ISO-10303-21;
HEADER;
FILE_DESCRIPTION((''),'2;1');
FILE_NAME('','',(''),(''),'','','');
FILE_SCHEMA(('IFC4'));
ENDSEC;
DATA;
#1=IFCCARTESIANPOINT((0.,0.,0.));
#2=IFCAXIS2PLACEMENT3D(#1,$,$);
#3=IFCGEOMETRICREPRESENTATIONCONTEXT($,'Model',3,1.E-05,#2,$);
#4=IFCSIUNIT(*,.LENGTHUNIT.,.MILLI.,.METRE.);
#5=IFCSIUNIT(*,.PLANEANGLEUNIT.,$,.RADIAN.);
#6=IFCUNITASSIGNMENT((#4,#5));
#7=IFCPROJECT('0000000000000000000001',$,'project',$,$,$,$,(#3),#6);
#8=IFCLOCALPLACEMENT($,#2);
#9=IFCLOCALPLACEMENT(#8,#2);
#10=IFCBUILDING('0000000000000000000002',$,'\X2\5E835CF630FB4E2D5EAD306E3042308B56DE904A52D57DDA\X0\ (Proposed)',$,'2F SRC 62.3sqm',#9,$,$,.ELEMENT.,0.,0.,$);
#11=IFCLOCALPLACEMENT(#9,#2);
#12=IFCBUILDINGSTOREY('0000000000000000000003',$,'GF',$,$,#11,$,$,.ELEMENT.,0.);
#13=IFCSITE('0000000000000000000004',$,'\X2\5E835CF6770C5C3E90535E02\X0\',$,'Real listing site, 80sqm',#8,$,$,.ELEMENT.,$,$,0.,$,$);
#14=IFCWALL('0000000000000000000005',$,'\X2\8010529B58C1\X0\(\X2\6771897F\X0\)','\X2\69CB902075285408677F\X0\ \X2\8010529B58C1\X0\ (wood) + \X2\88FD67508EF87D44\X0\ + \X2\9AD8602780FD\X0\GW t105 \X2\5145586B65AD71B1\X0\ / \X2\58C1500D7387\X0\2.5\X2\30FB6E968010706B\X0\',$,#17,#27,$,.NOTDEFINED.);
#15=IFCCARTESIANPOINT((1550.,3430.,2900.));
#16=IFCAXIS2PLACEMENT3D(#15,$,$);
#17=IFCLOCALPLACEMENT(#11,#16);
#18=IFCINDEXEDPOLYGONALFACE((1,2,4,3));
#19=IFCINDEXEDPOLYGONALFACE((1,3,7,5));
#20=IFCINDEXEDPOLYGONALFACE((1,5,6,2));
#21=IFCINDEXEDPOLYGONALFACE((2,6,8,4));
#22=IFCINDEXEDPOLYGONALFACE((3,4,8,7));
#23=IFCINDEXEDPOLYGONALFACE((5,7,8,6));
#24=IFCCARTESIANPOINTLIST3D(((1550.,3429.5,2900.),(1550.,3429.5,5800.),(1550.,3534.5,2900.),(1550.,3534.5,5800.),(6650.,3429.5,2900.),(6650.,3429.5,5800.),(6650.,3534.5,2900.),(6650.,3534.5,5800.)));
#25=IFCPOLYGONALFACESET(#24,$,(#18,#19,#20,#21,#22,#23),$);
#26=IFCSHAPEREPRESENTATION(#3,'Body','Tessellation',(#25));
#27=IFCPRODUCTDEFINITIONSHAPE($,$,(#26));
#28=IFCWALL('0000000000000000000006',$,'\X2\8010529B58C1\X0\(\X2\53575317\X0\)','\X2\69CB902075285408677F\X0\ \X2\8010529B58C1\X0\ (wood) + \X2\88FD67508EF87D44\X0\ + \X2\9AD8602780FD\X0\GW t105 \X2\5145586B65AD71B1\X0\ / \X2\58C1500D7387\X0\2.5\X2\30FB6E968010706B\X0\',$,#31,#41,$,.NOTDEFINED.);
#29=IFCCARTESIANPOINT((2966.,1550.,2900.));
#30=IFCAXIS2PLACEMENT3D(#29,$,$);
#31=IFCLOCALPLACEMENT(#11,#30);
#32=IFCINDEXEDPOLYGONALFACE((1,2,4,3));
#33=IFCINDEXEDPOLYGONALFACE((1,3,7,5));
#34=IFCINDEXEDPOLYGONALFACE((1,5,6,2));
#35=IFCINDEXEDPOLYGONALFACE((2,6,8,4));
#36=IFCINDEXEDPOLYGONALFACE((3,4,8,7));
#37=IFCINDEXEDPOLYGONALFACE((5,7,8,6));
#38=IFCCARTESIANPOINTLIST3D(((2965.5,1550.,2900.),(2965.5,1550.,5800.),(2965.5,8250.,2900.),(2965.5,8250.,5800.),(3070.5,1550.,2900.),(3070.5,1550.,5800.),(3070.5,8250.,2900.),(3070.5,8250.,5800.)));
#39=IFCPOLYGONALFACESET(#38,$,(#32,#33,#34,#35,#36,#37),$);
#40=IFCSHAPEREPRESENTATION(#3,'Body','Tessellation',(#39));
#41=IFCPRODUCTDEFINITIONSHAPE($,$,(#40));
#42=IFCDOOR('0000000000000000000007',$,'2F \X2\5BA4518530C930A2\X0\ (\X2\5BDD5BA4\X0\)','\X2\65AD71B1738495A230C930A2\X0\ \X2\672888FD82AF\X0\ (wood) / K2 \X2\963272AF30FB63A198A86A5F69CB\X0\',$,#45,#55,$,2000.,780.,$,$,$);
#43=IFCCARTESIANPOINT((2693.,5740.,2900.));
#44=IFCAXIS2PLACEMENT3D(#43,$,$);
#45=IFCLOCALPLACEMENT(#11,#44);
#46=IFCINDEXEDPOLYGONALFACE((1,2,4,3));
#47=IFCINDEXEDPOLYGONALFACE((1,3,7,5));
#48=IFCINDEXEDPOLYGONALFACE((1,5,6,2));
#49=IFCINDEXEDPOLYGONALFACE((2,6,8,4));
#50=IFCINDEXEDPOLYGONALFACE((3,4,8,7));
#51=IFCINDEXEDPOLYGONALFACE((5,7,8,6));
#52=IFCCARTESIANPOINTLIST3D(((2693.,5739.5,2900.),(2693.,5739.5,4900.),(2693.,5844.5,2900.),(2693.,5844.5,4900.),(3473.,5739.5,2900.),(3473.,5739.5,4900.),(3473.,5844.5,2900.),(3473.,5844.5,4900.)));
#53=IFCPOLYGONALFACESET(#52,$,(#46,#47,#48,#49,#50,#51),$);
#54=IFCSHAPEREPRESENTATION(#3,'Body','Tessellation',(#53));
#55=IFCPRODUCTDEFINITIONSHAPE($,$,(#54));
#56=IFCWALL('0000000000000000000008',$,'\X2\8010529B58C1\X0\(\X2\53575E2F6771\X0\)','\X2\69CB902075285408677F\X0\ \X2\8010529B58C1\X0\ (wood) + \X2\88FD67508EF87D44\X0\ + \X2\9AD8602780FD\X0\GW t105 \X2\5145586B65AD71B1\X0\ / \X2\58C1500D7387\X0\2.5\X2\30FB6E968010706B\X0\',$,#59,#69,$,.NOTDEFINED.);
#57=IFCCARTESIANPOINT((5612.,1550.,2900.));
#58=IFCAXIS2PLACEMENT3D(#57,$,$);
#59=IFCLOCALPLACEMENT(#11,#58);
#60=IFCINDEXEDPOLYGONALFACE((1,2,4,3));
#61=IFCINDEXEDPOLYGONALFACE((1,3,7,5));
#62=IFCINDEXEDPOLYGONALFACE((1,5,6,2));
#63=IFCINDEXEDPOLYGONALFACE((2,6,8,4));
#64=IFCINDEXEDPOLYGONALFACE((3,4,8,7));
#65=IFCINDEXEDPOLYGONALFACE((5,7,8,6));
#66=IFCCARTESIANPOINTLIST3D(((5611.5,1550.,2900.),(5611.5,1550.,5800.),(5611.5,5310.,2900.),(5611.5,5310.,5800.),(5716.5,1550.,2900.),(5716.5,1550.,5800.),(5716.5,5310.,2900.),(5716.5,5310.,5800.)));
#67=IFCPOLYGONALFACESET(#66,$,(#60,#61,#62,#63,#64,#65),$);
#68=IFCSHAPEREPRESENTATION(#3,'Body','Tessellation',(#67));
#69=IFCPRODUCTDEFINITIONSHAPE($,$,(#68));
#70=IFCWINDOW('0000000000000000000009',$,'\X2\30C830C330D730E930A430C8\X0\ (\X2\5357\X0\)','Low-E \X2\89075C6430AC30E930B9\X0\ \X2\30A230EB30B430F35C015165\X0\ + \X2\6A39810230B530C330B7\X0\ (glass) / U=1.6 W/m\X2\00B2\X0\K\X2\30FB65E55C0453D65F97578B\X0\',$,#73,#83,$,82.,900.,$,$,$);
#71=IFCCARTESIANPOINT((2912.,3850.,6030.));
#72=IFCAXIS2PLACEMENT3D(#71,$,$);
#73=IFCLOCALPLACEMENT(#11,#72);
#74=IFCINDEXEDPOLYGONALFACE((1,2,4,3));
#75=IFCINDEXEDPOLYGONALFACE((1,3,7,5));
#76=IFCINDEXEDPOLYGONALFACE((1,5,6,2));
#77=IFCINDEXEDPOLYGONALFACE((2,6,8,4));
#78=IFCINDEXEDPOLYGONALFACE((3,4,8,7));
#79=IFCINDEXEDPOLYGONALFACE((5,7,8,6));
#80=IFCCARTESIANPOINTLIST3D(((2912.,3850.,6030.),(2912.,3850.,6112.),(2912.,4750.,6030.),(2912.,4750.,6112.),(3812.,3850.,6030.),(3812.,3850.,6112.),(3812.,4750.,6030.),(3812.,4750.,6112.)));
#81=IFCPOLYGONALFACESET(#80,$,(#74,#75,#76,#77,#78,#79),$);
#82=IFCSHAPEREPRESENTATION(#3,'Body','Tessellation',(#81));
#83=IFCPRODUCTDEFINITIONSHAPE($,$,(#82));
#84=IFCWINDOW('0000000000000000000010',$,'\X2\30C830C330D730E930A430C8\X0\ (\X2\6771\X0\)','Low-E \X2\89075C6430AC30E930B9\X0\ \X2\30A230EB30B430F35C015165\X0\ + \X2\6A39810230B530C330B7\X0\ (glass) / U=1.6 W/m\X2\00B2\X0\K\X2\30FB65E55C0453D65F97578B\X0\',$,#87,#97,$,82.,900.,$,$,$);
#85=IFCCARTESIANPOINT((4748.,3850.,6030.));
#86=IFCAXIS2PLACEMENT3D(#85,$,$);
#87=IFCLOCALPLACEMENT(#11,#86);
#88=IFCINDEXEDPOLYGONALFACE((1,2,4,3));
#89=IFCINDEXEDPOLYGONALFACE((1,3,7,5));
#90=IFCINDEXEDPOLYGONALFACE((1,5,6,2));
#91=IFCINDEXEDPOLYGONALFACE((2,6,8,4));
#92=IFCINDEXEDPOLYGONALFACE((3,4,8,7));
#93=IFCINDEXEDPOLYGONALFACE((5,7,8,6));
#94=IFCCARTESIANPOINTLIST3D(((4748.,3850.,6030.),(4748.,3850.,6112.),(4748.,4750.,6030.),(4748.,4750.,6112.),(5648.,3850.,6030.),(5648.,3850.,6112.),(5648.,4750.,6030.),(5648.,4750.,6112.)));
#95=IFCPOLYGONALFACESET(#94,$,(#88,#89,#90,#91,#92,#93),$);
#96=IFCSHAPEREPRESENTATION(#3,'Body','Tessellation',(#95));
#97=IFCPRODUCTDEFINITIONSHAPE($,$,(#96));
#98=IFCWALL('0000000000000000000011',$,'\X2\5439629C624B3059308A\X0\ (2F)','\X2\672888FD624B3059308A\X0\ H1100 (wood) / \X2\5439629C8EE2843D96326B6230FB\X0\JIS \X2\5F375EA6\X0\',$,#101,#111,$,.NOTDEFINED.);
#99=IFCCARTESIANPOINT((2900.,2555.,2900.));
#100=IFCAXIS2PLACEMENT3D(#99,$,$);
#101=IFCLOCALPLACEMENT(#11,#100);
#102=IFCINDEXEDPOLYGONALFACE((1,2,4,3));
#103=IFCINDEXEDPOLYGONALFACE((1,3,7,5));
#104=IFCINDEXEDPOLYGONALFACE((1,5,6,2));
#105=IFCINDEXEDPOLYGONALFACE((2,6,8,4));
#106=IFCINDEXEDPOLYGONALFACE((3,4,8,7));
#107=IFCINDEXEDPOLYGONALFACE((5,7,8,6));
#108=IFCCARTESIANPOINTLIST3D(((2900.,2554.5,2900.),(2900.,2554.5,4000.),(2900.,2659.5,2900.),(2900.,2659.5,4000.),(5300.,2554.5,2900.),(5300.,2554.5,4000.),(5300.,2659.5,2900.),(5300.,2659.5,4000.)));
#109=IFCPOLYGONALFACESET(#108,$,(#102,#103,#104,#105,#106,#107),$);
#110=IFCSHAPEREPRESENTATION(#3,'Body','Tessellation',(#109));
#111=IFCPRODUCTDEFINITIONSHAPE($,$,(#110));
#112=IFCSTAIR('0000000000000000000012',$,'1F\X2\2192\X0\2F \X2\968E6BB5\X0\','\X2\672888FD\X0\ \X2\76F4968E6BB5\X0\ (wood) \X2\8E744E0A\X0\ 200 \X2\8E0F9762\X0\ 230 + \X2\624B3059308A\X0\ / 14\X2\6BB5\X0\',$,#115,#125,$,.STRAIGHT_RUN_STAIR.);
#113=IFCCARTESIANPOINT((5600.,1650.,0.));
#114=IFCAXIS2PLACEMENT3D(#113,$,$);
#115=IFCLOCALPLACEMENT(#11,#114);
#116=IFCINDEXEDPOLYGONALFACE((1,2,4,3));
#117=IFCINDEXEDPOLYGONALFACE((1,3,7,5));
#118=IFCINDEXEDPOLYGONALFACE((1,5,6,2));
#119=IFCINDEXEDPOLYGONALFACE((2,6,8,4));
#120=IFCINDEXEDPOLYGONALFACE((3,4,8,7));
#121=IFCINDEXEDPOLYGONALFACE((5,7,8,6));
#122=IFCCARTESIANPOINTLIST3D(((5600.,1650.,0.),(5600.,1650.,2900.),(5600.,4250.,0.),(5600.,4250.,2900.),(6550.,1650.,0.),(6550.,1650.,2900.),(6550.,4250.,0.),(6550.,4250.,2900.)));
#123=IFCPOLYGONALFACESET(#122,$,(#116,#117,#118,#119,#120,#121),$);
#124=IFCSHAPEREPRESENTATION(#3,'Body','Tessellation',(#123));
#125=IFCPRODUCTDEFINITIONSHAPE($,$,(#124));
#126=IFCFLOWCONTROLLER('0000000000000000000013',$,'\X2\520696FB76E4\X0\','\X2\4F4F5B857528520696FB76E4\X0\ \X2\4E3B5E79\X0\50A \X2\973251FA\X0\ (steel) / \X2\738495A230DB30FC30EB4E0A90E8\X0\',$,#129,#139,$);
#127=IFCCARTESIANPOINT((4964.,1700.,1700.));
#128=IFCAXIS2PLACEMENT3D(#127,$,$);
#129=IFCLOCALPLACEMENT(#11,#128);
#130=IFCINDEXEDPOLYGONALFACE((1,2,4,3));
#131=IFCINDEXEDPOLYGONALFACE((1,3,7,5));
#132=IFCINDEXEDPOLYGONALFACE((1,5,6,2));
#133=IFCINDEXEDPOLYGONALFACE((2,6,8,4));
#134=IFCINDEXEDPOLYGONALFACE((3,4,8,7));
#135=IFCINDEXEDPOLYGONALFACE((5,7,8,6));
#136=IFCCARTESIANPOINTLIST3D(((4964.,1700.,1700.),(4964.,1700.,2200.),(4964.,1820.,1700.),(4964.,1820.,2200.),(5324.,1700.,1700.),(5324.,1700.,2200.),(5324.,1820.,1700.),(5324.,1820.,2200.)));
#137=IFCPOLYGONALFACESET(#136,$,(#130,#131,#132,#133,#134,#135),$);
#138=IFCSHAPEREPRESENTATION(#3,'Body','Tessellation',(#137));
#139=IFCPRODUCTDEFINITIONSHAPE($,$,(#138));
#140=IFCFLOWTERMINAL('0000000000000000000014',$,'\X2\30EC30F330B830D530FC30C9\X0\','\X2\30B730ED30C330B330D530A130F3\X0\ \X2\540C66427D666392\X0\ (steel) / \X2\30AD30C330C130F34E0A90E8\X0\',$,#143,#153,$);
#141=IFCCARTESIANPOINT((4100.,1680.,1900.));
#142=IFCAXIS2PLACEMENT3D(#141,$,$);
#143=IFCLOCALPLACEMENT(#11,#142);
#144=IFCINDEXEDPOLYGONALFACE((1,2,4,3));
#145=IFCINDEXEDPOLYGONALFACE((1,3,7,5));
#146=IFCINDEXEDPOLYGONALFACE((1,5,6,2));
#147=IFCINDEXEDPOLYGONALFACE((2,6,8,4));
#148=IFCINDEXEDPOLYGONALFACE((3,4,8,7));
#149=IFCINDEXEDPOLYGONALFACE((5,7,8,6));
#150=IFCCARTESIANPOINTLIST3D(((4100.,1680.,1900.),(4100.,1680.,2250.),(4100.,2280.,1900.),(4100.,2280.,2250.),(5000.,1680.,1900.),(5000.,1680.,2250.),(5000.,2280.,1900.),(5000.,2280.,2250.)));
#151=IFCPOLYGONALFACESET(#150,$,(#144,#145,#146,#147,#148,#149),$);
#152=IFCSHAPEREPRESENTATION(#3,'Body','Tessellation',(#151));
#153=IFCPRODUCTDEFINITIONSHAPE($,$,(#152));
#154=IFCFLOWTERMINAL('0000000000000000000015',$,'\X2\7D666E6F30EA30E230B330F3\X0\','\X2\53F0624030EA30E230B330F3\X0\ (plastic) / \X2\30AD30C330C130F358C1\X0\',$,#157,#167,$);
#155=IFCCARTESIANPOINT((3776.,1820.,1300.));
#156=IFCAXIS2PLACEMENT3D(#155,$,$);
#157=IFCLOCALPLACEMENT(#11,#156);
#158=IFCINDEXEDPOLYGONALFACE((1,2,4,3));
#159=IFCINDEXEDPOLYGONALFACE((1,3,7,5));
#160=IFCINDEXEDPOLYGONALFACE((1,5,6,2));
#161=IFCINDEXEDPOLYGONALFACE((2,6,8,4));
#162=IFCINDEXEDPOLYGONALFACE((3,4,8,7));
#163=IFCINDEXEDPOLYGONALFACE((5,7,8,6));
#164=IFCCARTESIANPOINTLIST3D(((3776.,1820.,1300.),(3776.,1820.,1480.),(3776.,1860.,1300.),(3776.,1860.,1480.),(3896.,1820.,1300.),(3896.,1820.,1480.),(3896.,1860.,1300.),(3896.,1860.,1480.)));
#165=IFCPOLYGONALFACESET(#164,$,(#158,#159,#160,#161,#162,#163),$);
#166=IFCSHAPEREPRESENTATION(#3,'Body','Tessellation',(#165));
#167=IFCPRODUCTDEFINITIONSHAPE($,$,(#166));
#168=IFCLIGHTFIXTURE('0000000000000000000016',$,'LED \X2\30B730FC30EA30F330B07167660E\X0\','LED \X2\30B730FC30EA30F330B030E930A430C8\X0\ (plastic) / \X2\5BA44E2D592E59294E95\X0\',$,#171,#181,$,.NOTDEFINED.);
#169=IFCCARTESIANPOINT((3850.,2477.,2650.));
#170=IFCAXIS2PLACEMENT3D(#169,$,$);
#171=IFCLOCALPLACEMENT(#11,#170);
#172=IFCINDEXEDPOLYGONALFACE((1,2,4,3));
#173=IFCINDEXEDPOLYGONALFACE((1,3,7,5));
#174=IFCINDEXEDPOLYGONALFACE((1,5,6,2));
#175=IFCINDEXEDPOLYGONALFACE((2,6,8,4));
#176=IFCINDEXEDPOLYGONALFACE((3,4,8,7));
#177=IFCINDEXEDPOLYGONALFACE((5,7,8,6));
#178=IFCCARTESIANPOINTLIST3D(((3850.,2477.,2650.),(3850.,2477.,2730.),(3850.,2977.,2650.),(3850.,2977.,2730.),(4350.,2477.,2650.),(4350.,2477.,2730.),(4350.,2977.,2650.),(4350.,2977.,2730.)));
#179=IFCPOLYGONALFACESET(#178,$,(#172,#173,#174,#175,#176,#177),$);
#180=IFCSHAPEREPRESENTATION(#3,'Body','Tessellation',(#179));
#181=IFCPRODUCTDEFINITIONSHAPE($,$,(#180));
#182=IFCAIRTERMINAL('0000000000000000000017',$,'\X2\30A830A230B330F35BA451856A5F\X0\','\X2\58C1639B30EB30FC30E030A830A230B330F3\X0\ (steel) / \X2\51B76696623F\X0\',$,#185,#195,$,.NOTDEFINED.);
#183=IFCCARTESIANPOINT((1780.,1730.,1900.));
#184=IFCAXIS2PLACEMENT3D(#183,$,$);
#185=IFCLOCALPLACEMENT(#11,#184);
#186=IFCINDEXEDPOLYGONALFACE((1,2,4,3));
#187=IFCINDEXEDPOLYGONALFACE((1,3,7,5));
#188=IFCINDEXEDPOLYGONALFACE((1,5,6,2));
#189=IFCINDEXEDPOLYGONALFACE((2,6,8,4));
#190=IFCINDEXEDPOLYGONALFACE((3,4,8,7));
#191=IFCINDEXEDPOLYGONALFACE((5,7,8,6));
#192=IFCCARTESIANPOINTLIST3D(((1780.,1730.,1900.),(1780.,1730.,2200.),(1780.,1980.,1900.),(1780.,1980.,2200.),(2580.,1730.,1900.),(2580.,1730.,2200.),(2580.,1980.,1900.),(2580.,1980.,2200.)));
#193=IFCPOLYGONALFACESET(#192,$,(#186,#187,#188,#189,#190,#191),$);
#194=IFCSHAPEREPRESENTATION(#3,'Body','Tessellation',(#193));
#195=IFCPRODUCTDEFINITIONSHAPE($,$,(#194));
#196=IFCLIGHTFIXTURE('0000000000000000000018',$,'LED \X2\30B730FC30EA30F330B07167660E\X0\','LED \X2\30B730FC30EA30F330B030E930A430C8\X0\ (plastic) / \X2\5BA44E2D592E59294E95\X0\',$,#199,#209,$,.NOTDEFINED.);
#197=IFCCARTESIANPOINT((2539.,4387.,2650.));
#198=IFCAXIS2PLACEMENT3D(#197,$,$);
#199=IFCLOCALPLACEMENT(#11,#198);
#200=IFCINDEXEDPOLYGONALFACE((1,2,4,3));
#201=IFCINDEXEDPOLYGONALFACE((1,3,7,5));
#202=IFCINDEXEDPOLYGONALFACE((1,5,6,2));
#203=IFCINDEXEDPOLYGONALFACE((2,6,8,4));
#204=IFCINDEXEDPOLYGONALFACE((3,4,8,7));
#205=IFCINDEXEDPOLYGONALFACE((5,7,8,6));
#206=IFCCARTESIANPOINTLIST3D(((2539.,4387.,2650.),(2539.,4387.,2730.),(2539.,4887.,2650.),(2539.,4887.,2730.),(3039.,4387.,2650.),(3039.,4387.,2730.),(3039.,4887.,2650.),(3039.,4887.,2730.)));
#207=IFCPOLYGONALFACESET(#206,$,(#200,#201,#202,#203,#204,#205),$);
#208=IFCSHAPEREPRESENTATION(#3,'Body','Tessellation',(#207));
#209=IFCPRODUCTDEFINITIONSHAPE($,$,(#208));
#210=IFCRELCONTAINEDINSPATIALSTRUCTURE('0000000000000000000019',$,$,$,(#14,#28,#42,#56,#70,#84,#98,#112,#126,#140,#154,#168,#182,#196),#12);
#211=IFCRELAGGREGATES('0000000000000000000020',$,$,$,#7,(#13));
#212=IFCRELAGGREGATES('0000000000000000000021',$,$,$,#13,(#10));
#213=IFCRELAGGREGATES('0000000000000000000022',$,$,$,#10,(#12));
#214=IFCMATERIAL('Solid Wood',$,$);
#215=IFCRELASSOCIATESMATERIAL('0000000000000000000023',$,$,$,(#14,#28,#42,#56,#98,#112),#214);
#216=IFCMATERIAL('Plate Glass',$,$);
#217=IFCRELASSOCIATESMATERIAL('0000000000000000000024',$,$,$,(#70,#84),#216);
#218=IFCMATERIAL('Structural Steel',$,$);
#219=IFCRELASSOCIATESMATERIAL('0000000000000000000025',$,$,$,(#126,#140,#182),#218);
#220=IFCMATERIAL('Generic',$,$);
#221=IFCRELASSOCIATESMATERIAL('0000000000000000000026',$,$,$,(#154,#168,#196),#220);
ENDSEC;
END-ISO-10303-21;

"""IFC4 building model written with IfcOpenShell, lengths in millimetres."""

from ifc_helpers import new_model, si_unit, frame, frame_2d, origin, place, context, project, spatial, rectangle, extrude, material, element, fill, save


model = new_model("IFC4")

# Units and contexts
model_context = context("Model", 3, precision=1e-05, world=origin())
ifc_project = project(units=[si_unit("LENGTHUNIT", "METRE", prefix="MILLI"), si_unit("PLANEANGLEUNIT", "RADIAN")], contexts=[model_context])

# Site, building, storey
site_placement = place(None, origin())
site = spatial("IfcSite", under=ifc_project, at=site_placement, Name="広島県尾道市", ObjectType="Real listing site, 80sqm", CompositionType="ELEMENT", RefElevation=0.0)
building_placement = place(site_placement, origin())
building = spatial("IfcBuilding", under=site, at=building_placement, Name="広島・中庭のある回遊動線 (Proposed)", ObjectType="2F SRC 62.3sqm", CompositionType="ELEMENT", ElevationOfRefHeight=0.0, ElevationOfTerrain=0.0)
storey_placement = place(building_placement, origin())
storey = spatial("IfcBuildingStorey", under=building, at=storey_placement, Name="GF", CompositionType="ELEMENT", Elevation=0.0)

# Shared definitions
ifc_material_1 = material(Name="Solid Wood")

# Wall
wall_1_placement = place(storey_placement, frame((1550.0, 3430.0, 2900.0)))
element("IfcWall", 1, at=wall_1_placement, inside=storey, material=ifc_material_1, Name="耐力壁(東西)", Description="構造用合板 耐力壁 (wood) + 製材軸組 + 高性能GW t105 充填断熱 / 壁倍率2.5・準耐火", PredefinedType="NOTDEFINED", context=model_context, shape_type="SweptSolid", body=[
    extrude(rectangle(XDim=5100.0, YDim=105.0, at=frame_2d((2550.0, 52.0))), frame((1550.0, 3430.0, 2900.0)), (0.0, 0.0, 1.0), 2900.0),
])

# Wall, opening, door
wall_2_placement = place(storey_placement, frame((2966.0, 1550.0, 2900.0)))
wall_2 = element("IfcWall", 2, at=wall_2_placement, inside=storey, material=ifc_material_1, Name="耐力壁(南北)", Description="構造用合板 耐力壁 (wood) + 製材軸組 + 高性能GW t105 充填断熱 / 壁倍率2.5・準耐火", PredefinedType="NOTDEFINED", context=model_context, shape_type="SweptSolid", body=[
    extrude(rectangle(XDim=105.0, YDim=6700.0, at=frame_2d((52.0, 3350.0))), frame((2966.0, 1550.0, 2900.0)), (0.0, 0.0, 1.0), 2900.0),
])
opening_placement = place(storey_placement, frame((2693.0, 5740.0, 2900.0)))
opening = element("IfcOpeningElement", 3, at=opening_placement, cuts=wall_2, PredefinedType="NOTDEFINED", context=model_context, shape_type="SweptSolid", body=[
    extrude(rectangle(XDim=780.0, YDim=105.0, at=frame_2d((390.0, 52.0))), frame((2693.0, 5740.0, 2900.0)), (0.0, 0.0, 1.0), 2000.0),
])
door_placement = place(storey_placement, frame((2693.0, 5740.0, 2900.0)))
door = element("IfcDoor", 4, at=door_placement, inside=storey, material=ifc_material_1, Name="2F 室内ドア (寝室)", Description="断熱玄関ドア 木製芯 (wood) / K2 防犯・採風機構", OverallHeight=2000.0, OverallWidth=780.0, context=model_context, shape_type="SweptSolid", body=[
    extrude(rectangle(XDim=780.0, YDim=105.0, at=frame_2d((390.0, 52.0))), frame((2693.0, 5740.0, 2900.0)), (0.0, 0.0, 1.0), 2000.0),
])
fill(opening, door)

# Wall
wall_3_placement = place(storey_placement, frame((5612.0, 1550.0, 2900.0)))
element("IfcWall", 5, at=wall_3_placement, inside=storey, material=ifc_material_1, Name="耐力壁(南帯東)", Description="構造用合板 耐力壁 (wood) + 製材軸組 + 高性能GW t105 充填断熱 / 壁倍率2.5・準耐火", PredefinedType="NOTDEFINED", context=model_context, shape_type="SweptSolid", body=[
    extrude(rectangle(XDim=105.0, YDim=3760.0, at=frame_2d((52.0, 1880.0))), frame((5612.0, 1550.0, 2900.0)), (0.0, 0.0, 1.0), 2900.0),
])

# Windows
ifc_material_2 = material(Name="Plate Glass")
window_1_placement = place(storey_placement, frame((2912.0, 3850.0, 6030.0)))
element("IfcWindow", 6, at=window_1_placement, inside=storey, material=ifc_material_2, Name="トップライト (南)", Description="Low-E 複層ガラス アルゴン封入 + 樹脂サッシ (glass) / U=1.6 W/m²K・日射取得型", OverallHeight=82.0, OverallWidth=900.0, context=model_context, shape_type="SweptSolid", body=[
    extrude(rectangle(XDim=900.0, YDim=900.0, at=frame_2d((450.0, 450.0))), frame((2912.0, 3850.0, 6030.0)), (0.0, 0.0, 1.0), 82.0),
])
window_2_placement = place(storey_placement, frame((4748.0, 3850.0, 6030.0)))
element("IfcWindow", 7, at=window_2_placement, inside=storey, material=ifc_material_2, Name="トップライト (東)", Description="Low-E 複層ガラス アルゴン封入 + 樹脂サッシ (glass) / U=1.6 W/m²K・日射取得型", OverallHeight=82.0, OverallWidth=900.0, context=model_context, shape_type="SweptSolid", body=[
    extrude(rectangle(XDim=900.0, YDim=900.0, at=frame_2d((450.0, 450.0))), frame((4748.0, 3850.0, 6030.0)), (0.0, 0.0, 1.0), 82.0),
])

# Wall
wall_4_placement = place(storey_placement, frame((2900.0, 2555.0, 2900.0)))
element("IfcWall", 8, at=wall_4_placement, inside=storey, material=ifc_material_1, Name="吹抜手すり (2F)", Description="木製手すり H1100 (wood) / 吹抜転落防止・JIS 強度", PredefinedType="NOTDEFINED", context=model_context, shape_type="SweptSolid", body=[
    extrude(rectangle(XDim=2400.0, YDim=105.0, at=frame_2d((1200.0, 52.0))), frame((2900.0, 2555.0, 2900.0)), (0.0, 0.0, 1.0), 1100.0),
])

# Stair
stair_placement = place(storey_placement, frame((5600.0, 1650.0, 0.0)))
element("IfcStair", 9, at=stair_placement, inside=storey, material=ifc_material_1, Name="1F→2F 階段", Description="木製 直階段 (wood) 蹴上 200 踏面 230 + 手すり / 14段", PredefinedType="STRAIGHT_RUN_STAIR", context=model_context, shape_type="SweptSolid", body=[
    extrude(rectangle(XDim=950.0, YDim=2600.0, at=frame_2d((475.0, 1300.0))), frame((5600.0, 1650.0, 0.0)), (0.0, 0.0, 1.0), 2900.0),
])

# Shared definitions
ifc_material_3 = material(Name="Structural Steel")

# Flow controller
flow_controller_placement = place(storey_placement, frame((4964.0, 1700.0, 1700.0)))
element("IfcFlowController", 10, at=flow_controller_placement, inside=storey, material=ifc_material_3, Name="分電盤", Description="住宅用分電盤 主幹50A 露出 (steel) / 玄関ホール上部", context=model_context, shape_type="SweptSolid", body=[
    extrude(rectangle(XDim=360.0, YDim=120.0, at=frame_2d((180.0, 60.0))), frame((4964.0, 1700.0, 1700.0)), (0.0, 0.0, 1.0), 500.0),
])

# Flow terminals
flow_terminal_1_placement = place(storey_placement, frame((4100.0, 1680.0, 1900.0)))
element("IfcFlowTerminal", 11, at=flow_terminal_1_placement, inside=storey, material=ifc_material_3, Name="レンジフード", Description="シロッコファン 同時給排 (steel) / キッチン上部", context=model_context, shape_type="SweptSolid", body=[
    extrude(rectangle(XDim=900.0, YDim=600.0, at=frame_2d((450.0, 300.0))), frame((4100.0, 1680.0, 1900.0)), (0.0, 0.0, 1.0), 350.0),
])
ifc_material_4 = material(Name="Generic")
flow_terminal_2_placement = place(storey_placement, frame((3776.0, 1820.0, 1300.0)))
element("IfcFlowTerminal", 12, at=flow_terminal_2_placement, inside=storey, material=ifc_material_4, Name="給湯リモコン", Description="台所リモコン (plastic) / キッチン壁", context=model_context, shape_type="SweptSolid", body=[
    extrude(rectangle(XDim=120.0, YDim=40.0, at=frame_2d((60.0, 20.0))), frame((3776.0, 1820.0, 1300.0)), (0.0, 0.0, 1.0), 180.0),
])

# Light fixture
light_fixture_1_placement = place(storey_placement, frame((3850.0, 2477.0, 2650.0)))
element("IfcLightFixture", 13, at=light_fixture_1_placement, inside=storey, material=ifc_material_4, Name="LED シーリング照明", Description="LED シーリングライト (plastic) / 室中央天井", PredefinedType="NOTDEFINED", context=model_context, shape_type="SweptSolid", body=[
    extrude(rectangle(XDim=500.0, YDim=500.0, at=frame_2d((250.0, 250.0))), frame((3850.0, 2477.0, 2650.0)), (0.0, 0.0, 1.0), 80.0),
])

# Air terminal
air_terminal_1_placement = place(storey_placement, frame((1780.0, 1730.0, 1900.0)))
element("IfcAirTerminal", 14, at=air_terminal_1_placement, inside=storey, material=ifc_material_3, Name="エアコン室内機", Description="壁掛ルームエアコン (steel) / 冷暖房", PredefinedType="NOTDEFINED", context=model_context, shape_type="SweptSolid", body=[
    extrude(rectangle(XDim=800.0, YDim=250.0, at=frame_2d((400.0, 125.0))), frame((1780.0, 1730.0, 1900.0)), (0.0, 0.0, 1.0), 300.0),
])

# Light fixture
light_fixture_2_placement = place(storey_placement, frame((2539.0, 4387.0, 2650.0)))
element("IfcLightFixture", 15, at=light_fixture_2_placement, inside=storey, material=ifc_material_4, Name="LED シーリング照明", Description="LED シーリングライト (plastic) / 室中央天井", PredefinedType="NOTDEFINED", context=model_context, shape_type="SweptSolid", body=[
    extrude(rectangle(XDim=500.0, YDim=500.0, at=frame_2d((250.0, 250.0))), frame((2539.0, 4387.0, 2650.0)), (0.0, 0.0, 1.0), 80.0),
])

save(model, "model.ifc")
